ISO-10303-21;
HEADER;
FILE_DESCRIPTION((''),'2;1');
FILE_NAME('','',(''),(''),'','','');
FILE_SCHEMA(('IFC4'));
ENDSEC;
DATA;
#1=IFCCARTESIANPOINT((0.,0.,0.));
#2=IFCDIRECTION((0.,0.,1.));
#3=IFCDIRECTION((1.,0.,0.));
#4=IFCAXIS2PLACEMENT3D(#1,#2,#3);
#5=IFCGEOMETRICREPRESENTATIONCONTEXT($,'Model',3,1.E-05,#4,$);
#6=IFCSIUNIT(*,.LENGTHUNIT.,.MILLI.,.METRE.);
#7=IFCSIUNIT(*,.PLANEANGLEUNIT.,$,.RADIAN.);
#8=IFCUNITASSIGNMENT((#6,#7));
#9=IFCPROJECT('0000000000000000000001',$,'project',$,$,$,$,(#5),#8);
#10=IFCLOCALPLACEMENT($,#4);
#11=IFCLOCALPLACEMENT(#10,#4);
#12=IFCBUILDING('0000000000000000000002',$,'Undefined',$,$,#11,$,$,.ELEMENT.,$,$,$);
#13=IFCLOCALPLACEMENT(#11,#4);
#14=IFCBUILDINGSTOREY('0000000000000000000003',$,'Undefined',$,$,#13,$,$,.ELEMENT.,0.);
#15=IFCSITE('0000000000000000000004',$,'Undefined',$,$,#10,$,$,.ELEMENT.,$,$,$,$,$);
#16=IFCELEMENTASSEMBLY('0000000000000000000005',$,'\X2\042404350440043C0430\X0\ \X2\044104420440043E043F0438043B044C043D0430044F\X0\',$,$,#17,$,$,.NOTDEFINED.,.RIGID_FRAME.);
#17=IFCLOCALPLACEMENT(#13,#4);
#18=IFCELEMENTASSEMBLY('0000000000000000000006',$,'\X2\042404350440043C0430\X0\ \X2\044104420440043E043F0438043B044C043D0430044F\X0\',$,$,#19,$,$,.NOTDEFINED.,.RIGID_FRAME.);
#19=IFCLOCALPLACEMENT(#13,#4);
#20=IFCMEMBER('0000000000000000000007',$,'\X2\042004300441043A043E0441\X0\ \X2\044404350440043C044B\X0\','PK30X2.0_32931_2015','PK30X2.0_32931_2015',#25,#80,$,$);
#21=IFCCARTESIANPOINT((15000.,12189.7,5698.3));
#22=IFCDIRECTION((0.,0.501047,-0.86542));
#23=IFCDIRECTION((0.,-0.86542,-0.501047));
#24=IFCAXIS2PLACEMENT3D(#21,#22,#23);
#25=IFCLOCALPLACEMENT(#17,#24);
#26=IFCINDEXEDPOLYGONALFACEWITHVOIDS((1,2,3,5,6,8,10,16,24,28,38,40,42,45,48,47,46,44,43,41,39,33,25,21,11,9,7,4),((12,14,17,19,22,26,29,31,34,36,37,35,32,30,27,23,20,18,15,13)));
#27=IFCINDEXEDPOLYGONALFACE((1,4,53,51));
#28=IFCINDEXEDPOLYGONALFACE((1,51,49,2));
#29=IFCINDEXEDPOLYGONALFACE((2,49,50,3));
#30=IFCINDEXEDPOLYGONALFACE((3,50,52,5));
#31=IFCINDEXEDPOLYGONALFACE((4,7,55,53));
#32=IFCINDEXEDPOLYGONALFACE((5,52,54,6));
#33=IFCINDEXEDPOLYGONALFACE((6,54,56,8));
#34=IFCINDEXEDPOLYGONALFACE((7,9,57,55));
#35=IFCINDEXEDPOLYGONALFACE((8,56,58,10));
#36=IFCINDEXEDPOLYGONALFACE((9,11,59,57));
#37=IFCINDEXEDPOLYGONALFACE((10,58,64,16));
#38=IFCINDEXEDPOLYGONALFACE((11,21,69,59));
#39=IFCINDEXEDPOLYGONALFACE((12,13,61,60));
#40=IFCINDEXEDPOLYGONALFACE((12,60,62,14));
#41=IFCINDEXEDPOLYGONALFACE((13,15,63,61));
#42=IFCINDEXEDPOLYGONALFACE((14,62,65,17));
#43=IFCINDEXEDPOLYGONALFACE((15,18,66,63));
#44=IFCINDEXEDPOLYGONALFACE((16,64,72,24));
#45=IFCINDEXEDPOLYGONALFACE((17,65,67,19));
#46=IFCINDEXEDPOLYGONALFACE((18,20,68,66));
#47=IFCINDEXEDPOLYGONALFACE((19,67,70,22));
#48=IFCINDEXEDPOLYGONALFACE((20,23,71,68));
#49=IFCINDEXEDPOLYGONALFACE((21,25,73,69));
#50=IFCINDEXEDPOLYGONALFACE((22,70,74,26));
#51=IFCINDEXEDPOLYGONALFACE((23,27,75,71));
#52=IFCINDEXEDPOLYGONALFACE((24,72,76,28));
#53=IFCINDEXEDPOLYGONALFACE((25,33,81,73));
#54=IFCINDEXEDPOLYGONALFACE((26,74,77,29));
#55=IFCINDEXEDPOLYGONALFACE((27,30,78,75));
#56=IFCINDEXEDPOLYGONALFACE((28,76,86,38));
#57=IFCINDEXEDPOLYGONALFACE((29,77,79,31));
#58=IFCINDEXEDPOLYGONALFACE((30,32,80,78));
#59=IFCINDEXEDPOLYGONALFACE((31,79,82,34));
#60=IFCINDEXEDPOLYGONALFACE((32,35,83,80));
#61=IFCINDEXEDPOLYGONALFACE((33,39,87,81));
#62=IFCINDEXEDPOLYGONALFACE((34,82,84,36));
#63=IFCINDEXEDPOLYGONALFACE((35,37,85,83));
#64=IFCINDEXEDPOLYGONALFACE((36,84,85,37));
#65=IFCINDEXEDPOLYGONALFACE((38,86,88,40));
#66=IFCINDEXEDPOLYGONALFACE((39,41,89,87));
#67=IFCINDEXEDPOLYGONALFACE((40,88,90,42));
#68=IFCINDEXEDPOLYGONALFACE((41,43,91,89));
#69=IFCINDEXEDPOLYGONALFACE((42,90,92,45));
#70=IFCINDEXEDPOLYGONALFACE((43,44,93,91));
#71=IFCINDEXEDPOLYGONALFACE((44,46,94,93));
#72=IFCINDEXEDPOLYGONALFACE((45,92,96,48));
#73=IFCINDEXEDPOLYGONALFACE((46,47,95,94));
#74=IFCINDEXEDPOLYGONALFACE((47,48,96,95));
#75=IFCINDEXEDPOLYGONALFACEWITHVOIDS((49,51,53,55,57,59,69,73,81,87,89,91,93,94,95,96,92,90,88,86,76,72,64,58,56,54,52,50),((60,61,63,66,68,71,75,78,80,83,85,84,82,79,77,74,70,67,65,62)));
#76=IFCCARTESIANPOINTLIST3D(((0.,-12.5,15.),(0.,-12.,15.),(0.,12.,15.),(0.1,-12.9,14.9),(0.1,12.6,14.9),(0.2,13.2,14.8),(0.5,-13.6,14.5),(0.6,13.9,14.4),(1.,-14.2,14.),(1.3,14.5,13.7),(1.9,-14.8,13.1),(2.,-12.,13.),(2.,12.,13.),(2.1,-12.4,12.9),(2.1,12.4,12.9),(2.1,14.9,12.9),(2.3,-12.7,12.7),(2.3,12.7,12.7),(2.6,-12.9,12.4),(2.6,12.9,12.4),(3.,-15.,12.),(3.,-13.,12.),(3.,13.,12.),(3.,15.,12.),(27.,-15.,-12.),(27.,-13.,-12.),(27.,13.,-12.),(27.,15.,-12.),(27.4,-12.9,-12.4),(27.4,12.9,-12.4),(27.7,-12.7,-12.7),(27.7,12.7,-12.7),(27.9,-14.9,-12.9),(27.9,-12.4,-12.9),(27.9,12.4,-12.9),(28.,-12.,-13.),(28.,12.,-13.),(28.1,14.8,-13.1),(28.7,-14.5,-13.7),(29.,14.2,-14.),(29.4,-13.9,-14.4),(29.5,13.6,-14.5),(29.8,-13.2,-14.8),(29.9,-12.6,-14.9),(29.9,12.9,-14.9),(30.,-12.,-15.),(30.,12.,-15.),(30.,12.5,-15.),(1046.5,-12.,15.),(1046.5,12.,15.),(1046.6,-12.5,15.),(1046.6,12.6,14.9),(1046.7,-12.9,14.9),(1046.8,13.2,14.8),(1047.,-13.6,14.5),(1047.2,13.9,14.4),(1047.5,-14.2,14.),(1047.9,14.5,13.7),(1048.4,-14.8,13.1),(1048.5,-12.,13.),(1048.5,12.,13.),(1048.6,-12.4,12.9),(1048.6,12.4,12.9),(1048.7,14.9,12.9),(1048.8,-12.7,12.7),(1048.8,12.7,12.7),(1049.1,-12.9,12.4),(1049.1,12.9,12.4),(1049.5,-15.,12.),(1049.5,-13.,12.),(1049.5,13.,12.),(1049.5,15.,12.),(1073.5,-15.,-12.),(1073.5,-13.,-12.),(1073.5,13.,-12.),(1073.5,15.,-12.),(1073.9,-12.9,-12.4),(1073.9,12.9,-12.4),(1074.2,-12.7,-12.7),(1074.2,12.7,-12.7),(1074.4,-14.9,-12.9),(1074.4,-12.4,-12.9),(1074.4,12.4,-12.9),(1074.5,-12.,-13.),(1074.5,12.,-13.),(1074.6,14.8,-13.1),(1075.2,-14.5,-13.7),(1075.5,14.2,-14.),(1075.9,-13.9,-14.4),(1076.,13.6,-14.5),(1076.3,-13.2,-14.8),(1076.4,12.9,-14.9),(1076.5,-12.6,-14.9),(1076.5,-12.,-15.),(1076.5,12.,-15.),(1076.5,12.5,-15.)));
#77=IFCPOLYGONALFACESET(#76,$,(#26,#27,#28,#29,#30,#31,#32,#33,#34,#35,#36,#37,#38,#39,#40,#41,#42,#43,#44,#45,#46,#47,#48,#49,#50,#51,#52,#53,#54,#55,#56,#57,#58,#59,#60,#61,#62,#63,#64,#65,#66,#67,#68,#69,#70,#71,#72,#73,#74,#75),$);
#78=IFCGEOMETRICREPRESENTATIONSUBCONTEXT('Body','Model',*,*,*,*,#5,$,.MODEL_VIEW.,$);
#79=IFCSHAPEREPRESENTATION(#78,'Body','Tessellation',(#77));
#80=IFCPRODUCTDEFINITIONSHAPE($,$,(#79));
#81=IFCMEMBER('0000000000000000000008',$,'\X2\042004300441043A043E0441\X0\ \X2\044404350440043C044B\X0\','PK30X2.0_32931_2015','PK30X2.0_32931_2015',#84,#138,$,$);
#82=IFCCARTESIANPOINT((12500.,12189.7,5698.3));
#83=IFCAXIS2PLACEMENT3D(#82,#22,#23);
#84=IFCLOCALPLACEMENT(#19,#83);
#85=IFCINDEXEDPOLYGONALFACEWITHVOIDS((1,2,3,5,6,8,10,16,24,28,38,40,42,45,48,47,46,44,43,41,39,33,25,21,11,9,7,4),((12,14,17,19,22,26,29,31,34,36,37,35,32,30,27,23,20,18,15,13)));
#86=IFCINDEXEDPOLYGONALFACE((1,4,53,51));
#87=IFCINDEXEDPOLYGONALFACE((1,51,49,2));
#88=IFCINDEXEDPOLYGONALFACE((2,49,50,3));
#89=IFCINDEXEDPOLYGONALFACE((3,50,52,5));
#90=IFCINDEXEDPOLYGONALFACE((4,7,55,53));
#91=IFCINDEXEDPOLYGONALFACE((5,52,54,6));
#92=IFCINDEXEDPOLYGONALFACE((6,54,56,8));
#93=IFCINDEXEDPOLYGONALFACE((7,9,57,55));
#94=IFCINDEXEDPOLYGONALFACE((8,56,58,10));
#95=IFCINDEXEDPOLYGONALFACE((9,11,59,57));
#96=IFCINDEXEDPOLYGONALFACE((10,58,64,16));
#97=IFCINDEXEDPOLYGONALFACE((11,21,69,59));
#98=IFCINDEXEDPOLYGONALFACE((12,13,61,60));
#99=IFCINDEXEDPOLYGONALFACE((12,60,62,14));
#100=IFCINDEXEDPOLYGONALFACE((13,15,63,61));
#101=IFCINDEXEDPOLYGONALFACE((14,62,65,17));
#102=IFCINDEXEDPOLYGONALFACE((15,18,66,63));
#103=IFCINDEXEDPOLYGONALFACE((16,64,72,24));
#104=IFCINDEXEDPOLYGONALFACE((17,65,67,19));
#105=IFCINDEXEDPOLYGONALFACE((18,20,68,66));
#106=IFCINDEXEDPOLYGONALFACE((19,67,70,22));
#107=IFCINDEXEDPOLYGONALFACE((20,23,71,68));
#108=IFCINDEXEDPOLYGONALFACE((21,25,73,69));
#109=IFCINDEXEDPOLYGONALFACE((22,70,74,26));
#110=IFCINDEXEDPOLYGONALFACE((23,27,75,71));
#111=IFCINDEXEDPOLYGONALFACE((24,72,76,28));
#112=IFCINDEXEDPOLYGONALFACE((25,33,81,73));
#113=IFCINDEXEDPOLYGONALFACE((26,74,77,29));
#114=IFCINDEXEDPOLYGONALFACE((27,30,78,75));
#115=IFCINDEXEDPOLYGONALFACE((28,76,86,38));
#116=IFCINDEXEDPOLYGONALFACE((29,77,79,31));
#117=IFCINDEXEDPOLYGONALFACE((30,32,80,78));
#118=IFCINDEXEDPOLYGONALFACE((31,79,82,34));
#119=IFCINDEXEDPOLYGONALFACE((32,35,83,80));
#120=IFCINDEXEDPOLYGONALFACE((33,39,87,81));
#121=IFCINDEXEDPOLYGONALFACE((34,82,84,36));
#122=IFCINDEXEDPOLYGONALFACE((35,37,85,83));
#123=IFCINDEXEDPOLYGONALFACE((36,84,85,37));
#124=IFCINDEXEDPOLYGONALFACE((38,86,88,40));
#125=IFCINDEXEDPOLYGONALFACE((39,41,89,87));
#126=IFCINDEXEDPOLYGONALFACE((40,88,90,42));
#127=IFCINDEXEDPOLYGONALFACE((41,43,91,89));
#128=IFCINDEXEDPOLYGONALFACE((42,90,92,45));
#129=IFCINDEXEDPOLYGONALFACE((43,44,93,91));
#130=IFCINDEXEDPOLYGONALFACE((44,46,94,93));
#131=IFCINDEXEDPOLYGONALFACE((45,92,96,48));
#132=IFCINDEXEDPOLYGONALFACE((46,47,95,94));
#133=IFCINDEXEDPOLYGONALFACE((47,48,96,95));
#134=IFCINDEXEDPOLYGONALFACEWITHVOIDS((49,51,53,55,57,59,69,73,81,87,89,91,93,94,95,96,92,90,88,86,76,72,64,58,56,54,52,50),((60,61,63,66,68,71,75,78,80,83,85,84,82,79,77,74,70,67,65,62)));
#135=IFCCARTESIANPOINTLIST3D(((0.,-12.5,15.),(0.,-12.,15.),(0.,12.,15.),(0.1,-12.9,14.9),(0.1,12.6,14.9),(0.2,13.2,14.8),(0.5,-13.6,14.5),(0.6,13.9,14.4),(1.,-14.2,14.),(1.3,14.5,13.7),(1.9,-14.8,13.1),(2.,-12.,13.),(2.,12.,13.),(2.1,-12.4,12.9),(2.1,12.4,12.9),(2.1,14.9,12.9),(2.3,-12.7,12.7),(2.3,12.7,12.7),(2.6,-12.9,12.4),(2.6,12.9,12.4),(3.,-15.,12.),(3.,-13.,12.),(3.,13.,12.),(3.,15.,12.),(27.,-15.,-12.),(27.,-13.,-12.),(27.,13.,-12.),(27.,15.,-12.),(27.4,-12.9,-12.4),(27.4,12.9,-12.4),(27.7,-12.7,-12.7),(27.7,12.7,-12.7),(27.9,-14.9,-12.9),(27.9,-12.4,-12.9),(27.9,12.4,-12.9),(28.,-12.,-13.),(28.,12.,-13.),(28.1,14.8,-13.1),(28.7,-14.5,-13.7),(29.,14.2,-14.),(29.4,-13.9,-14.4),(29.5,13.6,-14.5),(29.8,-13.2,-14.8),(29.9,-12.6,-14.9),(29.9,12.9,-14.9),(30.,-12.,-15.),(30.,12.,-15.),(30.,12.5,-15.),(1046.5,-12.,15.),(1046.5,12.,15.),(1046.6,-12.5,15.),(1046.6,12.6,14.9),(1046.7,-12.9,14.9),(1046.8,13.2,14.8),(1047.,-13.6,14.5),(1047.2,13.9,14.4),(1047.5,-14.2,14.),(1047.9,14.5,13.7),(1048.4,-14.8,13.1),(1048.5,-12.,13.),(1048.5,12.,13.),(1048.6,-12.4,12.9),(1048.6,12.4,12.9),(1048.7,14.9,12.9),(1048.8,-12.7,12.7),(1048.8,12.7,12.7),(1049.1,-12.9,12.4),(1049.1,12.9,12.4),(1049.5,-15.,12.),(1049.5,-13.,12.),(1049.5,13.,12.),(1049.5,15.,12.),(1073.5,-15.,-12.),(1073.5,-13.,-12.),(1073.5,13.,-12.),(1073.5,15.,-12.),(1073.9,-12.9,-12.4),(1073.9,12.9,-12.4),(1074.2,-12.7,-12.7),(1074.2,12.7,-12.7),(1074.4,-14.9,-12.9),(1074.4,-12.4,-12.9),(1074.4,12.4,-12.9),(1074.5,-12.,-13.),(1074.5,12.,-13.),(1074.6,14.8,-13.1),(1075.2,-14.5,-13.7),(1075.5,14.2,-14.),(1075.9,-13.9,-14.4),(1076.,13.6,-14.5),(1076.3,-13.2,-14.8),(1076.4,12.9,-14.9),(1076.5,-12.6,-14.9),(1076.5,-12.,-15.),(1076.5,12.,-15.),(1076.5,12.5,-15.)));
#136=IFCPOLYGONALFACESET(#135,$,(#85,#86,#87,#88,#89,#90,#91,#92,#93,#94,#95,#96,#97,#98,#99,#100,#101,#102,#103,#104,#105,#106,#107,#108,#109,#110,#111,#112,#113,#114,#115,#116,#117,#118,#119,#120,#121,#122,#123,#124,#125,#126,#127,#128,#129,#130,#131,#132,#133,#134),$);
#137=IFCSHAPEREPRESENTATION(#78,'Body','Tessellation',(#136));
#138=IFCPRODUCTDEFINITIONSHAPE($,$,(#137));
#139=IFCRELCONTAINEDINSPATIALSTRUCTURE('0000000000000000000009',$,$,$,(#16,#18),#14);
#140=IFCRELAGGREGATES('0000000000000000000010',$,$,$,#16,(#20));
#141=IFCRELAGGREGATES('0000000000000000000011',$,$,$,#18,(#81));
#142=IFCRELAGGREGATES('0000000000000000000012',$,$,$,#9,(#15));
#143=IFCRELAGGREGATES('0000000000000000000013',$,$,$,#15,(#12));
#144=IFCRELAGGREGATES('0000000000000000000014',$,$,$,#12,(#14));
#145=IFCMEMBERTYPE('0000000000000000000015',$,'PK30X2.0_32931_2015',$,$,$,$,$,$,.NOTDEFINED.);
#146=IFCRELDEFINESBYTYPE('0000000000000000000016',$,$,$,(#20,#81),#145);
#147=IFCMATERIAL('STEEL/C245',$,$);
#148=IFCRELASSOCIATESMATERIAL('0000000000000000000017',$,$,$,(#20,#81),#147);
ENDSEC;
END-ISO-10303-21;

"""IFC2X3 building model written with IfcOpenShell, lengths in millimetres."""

from ifc_helpers import new_model, si_unit, frame, origin_with_axes, origin_2d_with_axis, place, context, subcontext, project, spatial, hollow_rectangle, extrude, clip, halfspace, material, type_object, element, aggregate, save


model = new_model("IFC2X3")

# Units and contexts
model_context = context("Model", 3, precision=1e-05, world=origin_with_axes())
body_context = subcontext(model_context, "Body", "Model", "MODEL_VIEW")
ifc_project = project(units=[si_unit("LENGTHUNIT", "METRE", prefix="MILLI"), si_unit("PLANEANGLEUNIT", "RADIAN")], contexts=[model_context])

# Site, building, storey
site_placement = place(None, origin_with_axes())
site = spatial("IfcSite", under=ifc_project, at=site_placement, Name="Undefined", CompositionType="ELEMENT")
building_placement = place(site_placement, origin_with_axes())
building = spatial("IfcBuilding", under=site, at=building_placement, Name="Undefined", CompositionType="ELEMENT")
storey_placement = place(building_placement, origin_with_axes())
storey = spatial("IfcBuildingStorey", under=building, at=storey_placement, Name="Undefined", CompositionType="ELEMENT", Elevation=0.0)

# Shared definitions
ifc_material_1 = material(Name="STEEL/C245")

# Element assembly
assembly_1_placement = place(storey_placement, origin_with_axes())
assembly_1 = element("IfcElementAssembly", 1, at=assembly_1_placement, inside=storey, Name="Ферма стропильная", AssemblyPlace="NOTDEFINED", PredefinedType="RIGID_FRAME")

# Element assembly
assembly_2_placement = place(storey_placement, origin_with_axes())
assembly_2 = element("IfcElementAssembly", 2, at=assembly_2_placement, inside=storey, Name="Ферма стропильная", AssemblyPlace="NOTDEFINED", PredefinedType="RIGID_FRAME")

# Members
member_type_1 = type_object("IfcMemberType", Name="PK30X2.0_32931_2015", PredefinedType="NOTDEFINED")
member_1_placement = place(assembly_1_placement, frame((15000.0, 12189.7, 5698.3), z_axis=(0.0, 0.501047, -0.86542), x_axis=(0.0, -0.86542, -0.501047)))
member_1 = element("IfcMember", 3, at=member_1_placement, type_object=member_type_1, material=ifc_material_1, Name="Раскос фермы", Description="PK30X2.0_32931_2015", ObjectType="PK30X2.0_32931_2015", context=body_context, shape_type="Clipping", body=[
    clip(clip(extrude(hollow_rectangle(XDim=30.0, YDim=30.0, WallThickness=2.0, InnerFilletRadius=1.0, OuterFilletRadius=3.0, at=origin_2d_with_axis()), frame((1102.9, 0.0, 0.0), z_axis=(-1.0, 0.0, 0.0), x_axis=(0.0, -1.0, 0.0)), (0.0, 0.0, 1.0), 1129.2), halfspace(frame((1060.0, 0.0, 1.5), z_axis=(-0.707107, 0.0, -0.707107), x_axis=(0.707107, 0.0, -0.707107)), True)), halfspace(frame((34.5, 0.0, -19.5), z_axis=(-0.707107, 0.0, -0.707107), x_axis=(0.707107, 0.0, -0.707107)), False)),
])
aggregate(assembly_1, [member_1])
member_2_placement = place(assembly_2_placement, frame((12500.0, 12189.7, 5698.3), z_axis=(0.0, 0.501047, -0.86542), x_axis=(0.0, -0.86542, -0.501047)))
member_2 = element("IfcMember", 4, at=member_2_placement, type_object=member_type_1, material=ifc_material_1, Name="Раскос фермы", Description="PK30X2.0_32931_2015", ObjectType="PK30X2.0_32931_2015", context=body_context, shape_type="Clipping", body=[
    clip(clip(extrude(hollow_rectangle(XDim=30.0, YDim=30.0, WallThickness=2.0, InnerFilletRadius=1.0, OuterFilletRadius=3.0, at=origin_2d_with_axis()), frame((1102.9, 0.0, 0.0), z_axis=(-1.0, 0.0, 0.0), x_axis=(0.0, -1.0, 0.0)), (0.0, 0.0, 1.0), 1129.2), halfspace(frame((1060.0, 0.0, 1.5), z_axis=(-0.707107, 0.0, -0.707107), x_axis=(0.707107, 0.0, -0.707107)), True)), halfspace(frame((34.5, 0.0, -19.5), z_axis=(-0.707107, 0.0, -0.707107), x_axis=(0.707107, 0.0, -0.707107)), False)),
])
aggregate(assembly_2, [member_2])

save(model, "model.ifc")
